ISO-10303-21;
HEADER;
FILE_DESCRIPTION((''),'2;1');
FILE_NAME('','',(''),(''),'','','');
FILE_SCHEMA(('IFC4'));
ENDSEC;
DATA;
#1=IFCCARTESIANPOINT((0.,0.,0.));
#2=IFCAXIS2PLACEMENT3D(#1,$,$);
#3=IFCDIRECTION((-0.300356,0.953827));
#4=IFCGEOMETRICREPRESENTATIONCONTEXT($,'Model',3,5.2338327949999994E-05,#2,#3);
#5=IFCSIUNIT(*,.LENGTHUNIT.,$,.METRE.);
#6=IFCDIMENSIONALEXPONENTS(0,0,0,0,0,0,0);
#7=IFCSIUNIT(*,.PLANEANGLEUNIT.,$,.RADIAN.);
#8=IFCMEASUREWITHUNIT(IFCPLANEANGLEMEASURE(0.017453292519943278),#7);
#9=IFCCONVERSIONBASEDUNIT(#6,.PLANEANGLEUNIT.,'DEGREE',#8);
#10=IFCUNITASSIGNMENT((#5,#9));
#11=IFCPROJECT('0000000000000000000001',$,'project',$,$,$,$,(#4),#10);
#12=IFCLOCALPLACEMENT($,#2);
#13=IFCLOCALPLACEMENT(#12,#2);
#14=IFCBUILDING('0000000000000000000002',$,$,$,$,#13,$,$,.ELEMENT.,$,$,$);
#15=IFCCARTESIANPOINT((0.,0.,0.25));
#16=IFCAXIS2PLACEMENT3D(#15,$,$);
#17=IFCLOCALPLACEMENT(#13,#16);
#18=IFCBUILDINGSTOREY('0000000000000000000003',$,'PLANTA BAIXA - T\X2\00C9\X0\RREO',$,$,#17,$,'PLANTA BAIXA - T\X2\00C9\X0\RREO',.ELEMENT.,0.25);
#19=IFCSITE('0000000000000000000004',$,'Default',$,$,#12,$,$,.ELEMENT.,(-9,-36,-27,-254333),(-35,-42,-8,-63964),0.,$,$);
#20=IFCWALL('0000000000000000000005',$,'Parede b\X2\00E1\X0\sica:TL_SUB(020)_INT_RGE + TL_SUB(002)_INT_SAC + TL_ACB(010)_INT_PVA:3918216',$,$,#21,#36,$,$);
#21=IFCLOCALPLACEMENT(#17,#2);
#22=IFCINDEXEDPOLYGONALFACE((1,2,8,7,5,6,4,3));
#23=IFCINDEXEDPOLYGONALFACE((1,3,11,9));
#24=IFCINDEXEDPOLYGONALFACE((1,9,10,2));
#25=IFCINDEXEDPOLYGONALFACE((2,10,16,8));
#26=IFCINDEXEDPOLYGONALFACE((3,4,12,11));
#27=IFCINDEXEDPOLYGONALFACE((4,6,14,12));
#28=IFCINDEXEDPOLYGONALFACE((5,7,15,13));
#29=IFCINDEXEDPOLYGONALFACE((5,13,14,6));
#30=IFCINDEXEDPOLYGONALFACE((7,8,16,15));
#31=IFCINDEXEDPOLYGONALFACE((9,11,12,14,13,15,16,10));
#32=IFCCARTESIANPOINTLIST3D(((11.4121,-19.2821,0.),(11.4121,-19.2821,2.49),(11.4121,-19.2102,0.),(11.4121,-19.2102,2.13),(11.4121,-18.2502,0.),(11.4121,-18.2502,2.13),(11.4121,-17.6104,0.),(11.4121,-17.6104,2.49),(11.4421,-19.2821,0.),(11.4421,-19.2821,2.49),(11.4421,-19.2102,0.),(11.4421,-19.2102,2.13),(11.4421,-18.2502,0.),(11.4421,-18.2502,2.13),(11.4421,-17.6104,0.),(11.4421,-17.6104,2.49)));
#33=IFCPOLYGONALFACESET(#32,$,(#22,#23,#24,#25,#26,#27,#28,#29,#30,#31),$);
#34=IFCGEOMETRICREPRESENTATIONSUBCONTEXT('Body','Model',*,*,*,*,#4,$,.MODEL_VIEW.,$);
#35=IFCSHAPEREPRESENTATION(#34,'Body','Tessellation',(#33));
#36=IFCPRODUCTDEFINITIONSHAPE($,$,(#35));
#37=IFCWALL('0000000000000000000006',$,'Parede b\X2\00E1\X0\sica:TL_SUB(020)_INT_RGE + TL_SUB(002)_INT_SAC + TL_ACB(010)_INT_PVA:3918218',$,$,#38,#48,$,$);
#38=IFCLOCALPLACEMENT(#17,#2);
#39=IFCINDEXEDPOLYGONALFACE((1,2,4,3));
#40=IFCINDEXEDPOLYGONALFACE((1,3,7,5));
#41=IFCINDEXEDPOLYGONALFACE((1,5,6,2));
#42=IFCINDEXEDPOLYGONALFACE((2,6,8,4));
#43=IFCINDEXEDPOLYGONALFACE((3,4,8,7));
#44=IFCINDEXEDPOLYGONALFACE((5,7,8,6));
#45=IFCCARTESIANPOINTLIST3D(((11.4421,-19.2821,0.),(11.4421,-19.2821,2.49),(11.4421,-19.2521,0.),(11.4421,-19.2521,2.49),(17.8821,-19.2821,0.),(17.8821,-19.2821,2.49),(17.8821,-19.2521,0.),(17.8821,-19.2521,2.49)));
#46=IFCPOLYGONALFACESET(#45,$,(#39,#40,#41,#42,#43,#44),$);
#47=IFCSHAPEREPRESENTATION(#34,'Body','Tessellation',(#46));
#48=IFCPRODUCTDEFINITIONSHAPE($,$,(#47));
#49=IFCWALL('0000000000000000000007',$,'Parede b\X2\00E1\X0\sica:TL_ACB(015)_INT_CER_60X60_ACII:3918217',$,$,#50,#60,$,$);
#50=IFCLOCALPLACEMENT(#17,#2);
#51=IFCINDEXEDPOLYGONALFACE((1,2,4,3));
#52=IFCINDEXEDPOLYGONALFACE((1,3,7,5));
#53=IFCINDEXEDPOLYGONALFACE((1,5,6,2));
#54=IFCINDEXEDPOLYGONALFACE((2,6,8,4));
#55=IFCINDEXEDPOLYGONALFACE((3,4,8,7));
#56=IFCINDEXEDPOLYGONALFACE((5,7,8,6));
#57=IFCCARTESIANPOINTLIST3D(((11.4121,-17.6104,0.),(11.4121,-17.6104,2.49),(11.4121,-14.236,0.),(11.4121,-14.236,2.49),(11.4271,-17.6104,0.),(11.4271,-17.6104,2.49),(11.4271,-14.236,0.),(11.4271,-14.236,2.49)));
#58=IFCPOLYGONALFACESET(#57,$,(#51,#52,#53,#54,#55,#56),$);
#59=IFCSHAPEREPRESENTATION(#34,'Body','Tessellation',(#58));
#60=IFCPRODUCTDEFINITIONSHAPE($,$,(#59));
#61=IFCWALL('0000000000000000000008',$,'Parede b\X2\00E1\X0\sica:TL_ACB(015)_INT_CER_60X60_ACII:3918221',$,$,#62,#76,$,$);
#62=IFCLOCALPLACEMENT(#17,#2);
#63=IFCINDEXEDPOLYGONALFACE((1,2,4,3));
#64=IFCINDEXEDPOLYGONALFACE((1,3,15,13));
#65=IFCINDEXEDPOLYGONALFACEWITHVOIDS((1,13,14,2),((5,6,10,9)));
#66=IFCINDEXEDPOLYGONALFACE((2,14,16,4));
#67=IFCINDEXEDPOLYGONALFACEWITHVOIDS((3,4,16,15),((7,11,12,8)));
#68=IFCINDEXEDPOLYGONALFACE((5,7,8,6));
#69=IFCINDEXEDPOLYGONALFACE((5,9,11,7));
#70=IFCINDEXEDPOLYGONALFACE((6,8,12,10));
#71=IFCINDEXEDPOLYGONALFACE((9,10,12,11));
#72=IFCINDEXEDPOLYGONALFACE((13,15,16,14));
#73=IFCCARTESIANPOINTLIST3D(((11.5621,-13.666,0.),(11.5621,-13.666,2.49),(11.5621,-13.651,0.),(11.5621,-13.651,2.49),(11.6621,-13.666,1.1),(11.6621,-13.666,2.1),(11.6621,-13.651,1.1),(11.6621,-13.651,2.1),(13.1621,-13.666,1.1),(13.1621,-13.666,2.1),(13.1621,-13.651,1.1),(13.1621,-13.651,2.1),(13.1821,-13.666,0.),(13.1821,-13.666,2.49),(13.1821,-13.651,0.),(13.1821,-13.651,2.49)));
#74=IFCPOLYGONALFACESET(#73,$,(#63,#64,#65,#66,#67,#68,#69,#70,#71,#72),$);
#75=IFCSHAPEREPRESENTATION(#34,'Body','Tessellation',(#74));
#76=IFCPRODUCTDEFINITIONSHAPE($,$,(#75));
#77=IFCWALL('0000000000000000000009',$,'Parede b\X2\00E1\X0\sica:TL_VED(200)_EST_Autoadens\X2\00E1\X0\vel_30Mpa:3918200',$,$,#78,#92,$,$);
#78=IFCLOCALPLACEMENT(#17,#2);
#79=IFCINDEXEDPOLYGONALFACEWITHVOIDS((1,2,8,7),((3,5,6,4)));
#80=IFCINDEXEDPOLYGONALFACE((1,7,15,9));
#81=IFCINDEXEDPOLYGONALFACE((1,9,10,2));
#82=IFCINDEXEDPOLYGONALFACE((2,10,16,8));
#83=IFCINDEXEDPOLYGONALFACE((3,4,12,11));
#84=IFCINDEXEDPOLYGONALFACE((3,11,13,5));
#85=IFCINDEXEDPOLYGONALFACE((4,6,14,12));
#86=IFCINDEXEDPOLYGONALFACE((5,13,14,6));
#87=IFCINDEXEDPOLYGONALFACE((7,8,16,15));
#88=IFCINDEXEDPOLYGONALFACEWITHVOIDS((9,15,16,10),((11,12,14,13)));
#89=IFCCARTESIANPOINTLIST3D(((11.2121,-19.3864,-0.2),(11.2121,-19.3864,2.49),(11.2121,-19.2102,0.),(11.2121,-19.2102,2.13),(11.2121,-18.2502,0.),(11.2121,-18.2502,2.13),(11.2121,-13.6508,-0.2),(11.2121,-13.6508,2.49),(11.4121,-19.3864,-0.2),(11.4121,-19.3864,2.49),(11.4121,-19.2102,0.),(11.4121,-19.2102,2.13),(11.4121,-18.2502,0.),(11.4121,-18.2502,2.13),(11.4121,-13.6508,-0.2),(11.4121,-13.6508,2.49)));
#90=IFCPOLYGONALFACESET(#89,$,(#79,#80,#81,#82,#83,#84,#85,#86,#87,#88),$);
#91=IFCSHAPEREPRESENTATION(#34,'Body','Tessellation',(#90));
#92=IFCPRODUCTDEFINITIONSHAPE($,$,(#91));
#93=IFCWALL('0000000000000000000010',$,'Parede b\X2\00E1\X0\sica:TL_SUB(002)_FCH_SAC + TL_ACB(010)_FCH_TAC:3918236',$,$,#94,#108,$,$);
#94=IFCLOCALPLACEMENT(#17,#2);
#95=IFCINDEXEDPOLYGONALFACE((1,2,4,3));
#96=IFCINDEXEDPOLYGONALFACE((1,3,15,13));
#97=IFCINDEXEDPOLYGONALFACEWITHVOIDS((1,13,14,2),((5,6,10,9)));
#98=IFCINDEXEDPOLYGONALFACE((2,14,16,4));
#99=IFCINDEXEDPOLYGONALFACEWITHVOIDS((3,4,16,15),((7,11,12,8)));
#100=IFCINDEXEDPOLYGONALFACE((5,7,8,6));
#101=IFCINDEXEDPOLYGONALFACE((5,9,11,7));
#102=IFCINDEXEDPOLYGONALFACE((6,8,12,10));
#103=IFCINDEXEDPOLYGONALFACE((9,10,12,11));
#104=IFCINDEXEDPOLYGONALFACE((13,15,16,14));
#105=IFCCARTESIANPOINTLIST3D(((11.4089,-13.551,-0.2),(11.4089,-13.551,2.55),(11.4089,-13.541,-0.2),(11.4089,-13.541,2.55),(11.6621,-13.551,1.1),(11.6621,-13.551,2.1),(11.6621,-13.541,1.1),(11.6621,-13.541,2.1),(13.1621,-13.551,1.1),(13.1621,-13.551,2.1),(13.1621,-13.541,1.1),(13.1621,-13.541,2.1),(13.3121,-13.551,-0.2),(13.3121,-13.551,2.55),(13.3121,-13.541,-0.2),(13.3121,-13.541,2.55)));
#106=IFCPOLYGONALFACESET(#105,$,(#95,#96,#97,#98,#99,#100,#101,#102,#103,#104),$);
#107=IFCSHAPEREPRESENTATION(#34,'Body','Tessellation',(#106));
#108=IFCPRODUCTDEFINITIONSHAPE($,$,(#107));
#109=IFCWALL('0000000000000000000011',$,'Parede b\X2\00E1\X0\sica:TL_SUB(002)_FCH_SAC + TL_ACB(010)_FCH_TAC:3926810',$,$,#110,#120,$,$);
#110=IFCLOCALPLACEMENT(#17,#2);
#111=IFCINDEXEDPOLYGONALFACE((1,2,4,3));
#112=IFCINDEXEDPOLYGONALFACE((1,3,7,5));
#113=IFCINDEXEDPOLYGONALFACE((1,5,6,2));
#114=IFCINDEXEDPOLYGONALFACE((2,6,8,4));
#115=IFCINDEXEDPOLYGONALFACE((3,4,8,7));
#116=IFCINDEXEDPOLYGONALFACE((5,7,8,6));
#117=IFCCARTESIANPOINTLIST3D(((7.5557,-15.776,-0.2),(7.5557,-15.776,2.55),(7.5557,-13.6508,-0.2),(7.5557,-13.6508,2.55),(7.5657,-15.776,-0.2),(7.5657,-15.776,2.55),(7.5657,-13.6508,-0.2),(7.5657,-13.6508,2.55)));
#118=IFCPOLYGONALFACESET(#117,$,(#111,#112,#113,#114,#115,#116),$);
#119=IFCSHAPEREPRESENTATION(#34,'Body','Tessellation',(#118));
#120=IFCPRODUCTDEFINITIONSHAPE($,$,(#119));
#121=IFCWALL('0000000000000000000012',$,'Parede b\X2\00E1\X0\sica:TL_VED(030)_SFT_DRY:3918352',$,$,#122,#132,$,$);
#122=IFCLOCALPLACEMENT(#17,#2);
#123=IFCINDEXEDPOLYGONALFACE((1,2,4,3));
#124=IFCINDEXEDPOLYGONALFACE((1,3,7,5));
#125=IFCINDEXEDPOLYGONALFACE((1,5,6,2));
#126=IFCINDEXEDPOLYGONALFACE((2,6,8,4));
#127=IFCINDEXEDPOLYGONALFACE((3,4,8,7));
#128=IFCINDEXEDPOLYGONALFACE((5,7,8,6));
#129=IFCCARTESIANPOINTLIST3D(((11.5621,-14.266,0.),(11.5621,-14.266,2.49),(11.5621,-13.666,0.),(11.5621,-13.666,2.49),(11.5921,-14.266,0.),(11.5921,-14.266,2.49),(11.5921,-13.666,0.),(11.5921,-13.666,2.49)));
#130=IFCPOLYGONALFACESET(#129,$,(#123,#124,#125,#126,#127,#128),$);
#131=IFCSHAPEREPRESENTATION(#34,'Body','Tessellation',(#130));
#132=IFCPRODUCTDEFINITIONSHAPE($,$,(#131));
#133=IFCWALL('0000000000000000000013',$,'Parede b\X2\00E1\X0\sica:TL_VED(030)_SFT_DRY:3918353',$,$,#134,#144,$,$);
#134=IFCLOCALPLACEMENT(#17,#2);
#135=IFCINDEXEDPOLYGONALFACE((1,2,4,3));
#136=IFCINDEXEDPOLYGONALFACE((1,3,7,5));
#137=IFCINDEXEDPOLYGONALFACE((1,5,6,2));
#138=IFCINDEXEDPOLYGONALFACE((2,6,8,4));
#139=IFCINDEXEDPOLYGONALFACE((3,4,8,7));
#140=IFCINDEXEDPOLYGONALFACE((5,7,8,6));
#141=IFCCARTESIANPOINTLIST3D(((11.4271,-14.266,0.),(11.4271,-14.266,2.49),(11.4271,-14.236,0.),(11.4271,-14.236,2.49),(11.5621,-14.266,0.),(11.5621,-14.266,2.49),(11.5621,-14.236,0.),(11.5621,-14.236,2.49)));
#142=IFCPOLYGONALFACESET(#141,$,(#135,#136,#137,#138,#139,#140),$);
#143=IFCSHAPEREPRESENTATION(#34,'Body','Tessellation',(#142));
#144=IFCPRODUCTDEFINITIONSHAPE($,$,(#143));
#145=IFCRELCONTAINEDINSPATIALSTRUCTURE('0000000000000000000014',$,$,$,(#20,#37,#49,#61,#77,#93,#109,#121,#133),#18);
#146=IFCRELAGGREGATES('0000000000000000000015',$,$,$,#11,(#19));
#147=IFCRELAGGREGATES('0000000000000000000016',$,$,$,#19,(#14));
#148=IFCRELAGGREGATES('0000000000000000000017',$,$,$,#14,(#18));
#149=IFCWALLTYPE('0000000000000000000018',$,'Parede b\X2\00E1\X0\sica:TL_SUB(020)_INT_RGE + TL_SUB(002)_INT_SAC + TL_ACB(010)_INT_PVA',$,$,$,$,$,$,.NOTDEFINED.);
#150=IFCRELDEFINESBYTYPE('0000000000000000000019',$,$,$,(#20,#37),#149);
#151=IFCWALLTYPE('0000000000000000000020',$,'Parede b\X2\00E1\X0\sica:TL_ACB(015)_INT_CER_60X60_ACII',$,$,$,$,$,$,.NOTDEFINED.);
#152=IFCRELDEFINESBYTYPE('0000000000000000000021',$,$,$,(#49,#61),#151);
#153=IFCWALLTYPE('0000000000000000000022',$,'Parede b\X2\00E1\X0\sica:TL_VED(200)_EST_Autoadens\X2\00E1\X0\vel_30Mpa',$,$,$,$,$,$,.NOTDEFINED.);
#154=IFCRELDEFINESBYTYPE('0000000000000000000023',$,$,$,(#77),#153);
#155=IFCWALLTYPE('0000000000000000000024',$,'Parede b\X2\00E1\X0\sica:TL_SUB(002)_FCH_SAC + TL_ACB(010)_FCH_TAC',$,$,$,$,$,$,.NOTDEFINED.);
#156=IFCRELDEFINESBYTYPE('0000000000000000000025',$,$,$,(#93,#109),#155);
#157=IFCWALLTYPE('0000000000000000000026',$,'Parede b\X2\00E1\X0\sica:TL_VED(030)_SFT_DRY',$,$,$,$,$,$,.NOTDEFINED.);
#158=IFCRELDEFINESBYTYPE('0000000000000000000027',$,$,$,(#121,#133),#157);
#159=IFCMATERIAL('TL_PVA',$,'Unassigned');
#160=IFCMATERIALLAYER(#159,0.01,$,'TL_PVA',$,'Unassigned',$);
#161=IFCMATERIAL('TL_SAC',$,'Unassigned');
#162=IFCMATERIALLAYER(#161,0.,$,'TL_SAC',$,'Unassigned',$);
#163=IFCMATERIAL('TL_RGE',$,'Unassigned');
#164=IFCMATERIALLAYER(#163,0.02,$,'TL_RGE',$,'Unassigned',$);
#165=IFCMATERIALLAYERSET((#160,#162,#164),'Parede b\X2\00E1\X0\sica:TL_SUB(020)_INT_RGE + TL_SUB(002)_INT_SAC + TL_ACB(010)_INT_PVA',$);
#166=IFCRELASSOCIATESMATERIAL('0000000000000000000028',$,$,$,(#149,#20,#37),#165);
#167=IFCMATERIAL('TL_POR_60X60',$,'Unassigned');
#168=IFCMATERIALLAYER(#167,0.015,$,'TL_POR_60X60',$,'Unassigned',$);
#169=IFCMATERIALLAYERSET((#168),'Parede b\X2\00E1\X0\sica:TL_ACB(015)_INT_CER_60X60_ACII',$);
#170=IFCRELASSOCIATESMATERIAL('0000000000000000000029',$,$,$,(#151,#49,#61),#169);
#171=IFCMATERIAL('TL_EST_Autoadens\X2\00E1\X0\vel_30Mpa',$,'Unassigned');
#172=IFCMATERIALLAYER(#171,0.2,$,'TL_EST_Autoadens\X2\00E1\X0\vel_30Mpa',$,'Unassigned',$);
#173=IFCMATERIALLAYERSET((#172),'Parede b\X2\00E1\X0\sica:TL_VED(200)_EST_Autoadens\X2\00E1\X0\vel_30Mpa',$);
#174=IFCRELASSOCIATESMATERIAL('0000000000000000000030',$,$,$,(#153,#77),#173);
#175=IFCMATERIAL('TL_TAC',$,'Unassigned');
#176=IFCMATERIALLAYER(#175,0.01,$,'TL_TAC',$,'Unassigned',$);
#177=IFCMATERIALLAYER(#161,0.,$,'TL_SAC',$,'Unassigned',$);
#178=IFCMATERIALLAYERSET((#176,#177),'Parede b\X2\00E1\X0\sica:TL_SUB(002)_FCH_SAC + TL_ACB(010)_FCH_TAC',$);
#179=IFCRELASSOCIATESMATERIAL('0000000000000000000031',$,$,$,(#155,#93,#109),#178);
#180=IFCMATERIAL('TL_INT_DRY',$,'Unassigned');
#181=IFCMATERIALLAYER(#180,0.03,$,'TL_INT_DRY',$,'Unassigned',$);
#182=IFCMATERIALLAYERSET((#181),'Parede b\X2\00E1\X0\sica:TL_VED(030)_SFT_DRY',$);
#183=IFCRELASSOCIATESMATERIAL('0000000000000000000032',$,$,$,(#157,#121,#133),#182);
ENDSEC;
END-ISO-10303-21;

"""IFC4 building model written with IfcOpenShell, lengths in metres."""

from ifc_helpers import new_model, entity, si_unit, converted_unit, direction, frame, frame_2d, origin, place, context, subcontext, project, spatial, rectangle, extrude, material, layer, layer_set, layer_usage, type_object, element, save


model = new_model("IFC4")

# Units and contexts
model_context = context("Model", 3, precision=5.2338327949999994e-05, world=origin(), true_north=direction((-0.300356, 0.953827)))
body_context = subcontext(model_context, "Body", "Model", "MODEL_VIEW")
ifc_project = project(units=[si_unit("LENGTHUNIT", "METRE"), converted_unit("PLANEANGLEUNIT", "DEGREE", entity("IfcPlaneAngleMeasure", 0.017453292519943278), si_unit("PLANEANGLEUNIT", "RADIAN"), dimensions=[0, 0, 0, 0, 0, 0, 0])], contexts=[model_context])

# Site, building, storey
site_placement = place(None, origin())
site = spatial("IfcSite", under=ifc_project, at=site_placement, Name="Default", CompositionType="ELEMENT", RefLatitude=(-9, -36, -27, -254333), RefLongitude=(-35, -42, -8, -63964), RefElevation=0.0)
building_placement = place(site_placement, origin())
building = spatial("IfcBuilding", under=site, at=building_placement, CompositionType="ELEMENT")
storey_placement = place(building_placement, frame((0.0, 0.0, 0.25)))
storey = spatial("IfcBuildingStorey", under=building, at=storey_placement, Name="PLANTA BAIXA - TÉRREO", LongName="PLANTA BAIXA - TÉRREO", CompositionType="ELEMENT", Elevation=0.25)

# Shared definitions
ifc_material_1 = material(Name="TL_POR_60X60", Category="Unassigned")

# Shared definitions
ifc_material_2 = material(Name="TL_EST_Autoadensável_30Mpa", Category="Unassigned")

# Wall, opening
ifc_material_3 = material(Name="TL_PVA", Category="Unassigned")
ifc_layer_1 = layer(ifc_material_3, 0.01, Name="TL_PVA", Category="Unassigned")
ifc_material_4 = material(Name="TL_SAC", Category="Unassigned")
ifc_layer_2 = layer(ifc_material_4, 0.0, Name="TL_SAC", Category="Unassigned")
ifc_material_5 = material(Name="TL_RGE", Category="Unassigned")
ifc_layer_3 = layer(ifc_material_5, 0.02, Name="TL_RGE", Category="Unassigned")
ifc_layer_set_1 = layer_set([ifc_layer_1, ifc_layer_2, ifc_layer_3], Name="Parede básica:TL_SUB(020)_INT_RGE + TL_SUB(002)_INT_SAC + TL_ACB(010)_INT_PVA")
ifc_layer_usage_1 = layer_usage(ifc_layer_set_1, "AXIS2", "POSITIVE", -0.015)
wall_type_1 = type_object("IfcWallType", Name="Parede básica:TL_SUB(020)_INT_RGE + TL_SUB(002)_INT_SAC + TL_ACB(010)_INT_PVA", PredefinedType="NOTDEFINED", material=ifc_layer_set_1)
wall_1_placement = place(storey_placement, frame((11.4271, -19.2821, 0.0), z_axis=(0.0, 0.0, 1.0), x_axis=(0.0, 1.0, 0.0)))
wall_1 = element("IfcWall", 1, at=wall_1_placement, inside=storey, type_object=wall_type_1, material=ifc_layer_usage_1, Name="Parede básica:TL_SUB(020)_INT_RGE + TL_SUB(002)_INT_SAC + TL_ACB(010)_INT_PVA:3918216", context=body_context, shape_type="SweptSolid", body=[
    extrude(rectangle(XDim=1.6717, YDim=0.03, at=frame_2d((0.8359, 0.0), x_axis=(-1.0, 0.0))), origin(), (0.0, 0.0, 1.0), 2.49),
])
opening_1_placement = place(wall_1_placement, frame((19.2821, 11.4271, 0.0)))
element("IfcOpeningElement", 2, at=opening_1_placement, cuts=wall_1, PredefinedType="OPENING", context=body_context, shape_type="SweptSolid", body=[
    extrude(rectangle(XDim=2.13, YDim=0.96, at=frame_2d((0.0, 0.0), x_axis=(0.0, 1.0))), frame((-18.7302, -12.9361, 1.065), z_axis=(0.0, 1.0, 0.0), x_axis=(-1.0, 0.0, 0.0)), (0.0, 0.0, 1.0), 3.048),
])

# Walls
ifc_layer_usage_2 = layer_usage(ifc_layer_set_1, "AXIS2", "NEGATIVE", 0.015)
wall_2_placement = place(storey_placement, frame((11.4421, -19.2671, 0.0)))
element("IfcWall", 3, at=wall_2_placement, inside=storey, type_object=wall_type_1, material=ifc_layer_usage_2, Name="Parede básica:TL_SUB(020)_INT_RGE + TL_SUB(002)_INT_SAC + TL_ACB(010)_INT_PVA:3918218", context=body_context, shape_type="SweptSolid", body=[
    extrude(rectangle(XDim=6.44, YDim=0.03, at=frame_2d((3.22, 0.0), x_axis=(-1.0, 0.0))), origin(), (0.0, 0.0, 1.0), 2.49),
])
ifc_layer_4 = layer(ifc_material_1, 0.015, Name="TL_POR_60X60", Category="Unassigned")
ifc_layer_set_2 = layer_set([ifc_layer_4], Name="Parede básica:TL_ACB(015)_INT_CER_60X60_ACII")
ifc_layer_usage_3 = layer_usage(ifc_layer_set_2, "AXIS2", "POSITIVE", -0.0075)
wall_type_2 = type_object("IfcWallType", Name="Parede básica:TL_ACB(015)_INT_CER_60X60_ACII", PredefinedType="NOTDEFINED", material=ifc_layer_set_2)
wall_3_placement = place(storey_placement, frame((11.4196, -17.6104, 0.0), z_axis=(0.0, 0.0, 1.0), x_axis=(0.0, 1.0, 0.0)))
element("IfcWall", 4, at=wall_3_placement, inside=storey, type_object=wall_type_2, material=ifc_layer_usage_3, Name="Parede básica:TL_ACB(015)_INT_CER_60X60_ACII:3918217", context=body_context, shape_type="SweptSolid", body=[
    extrude(rectangle(XDim=3.3744, YDim=0.015, at=frame_2d((1.6872, 0.0), x_axis=(-1.0, 0.0))), origin(), (0.0, 0.0, 1.0), 2.49),
])

# Walls, openings
ifc_layer_usage_4 = layer_usage(ifc_layer_set_2, "AXIS2", "POSITIVE", -0.0075)
wall_4_placement = place(storey_placement, frame((11.5621, -13.6585, 0.0)))
wall_4 = element("IfcWall", 5, at=wall_4_placement, inside=storey, type_object=wall_type_2, material=ifc_layer_usage_4, Name="Parede básica:TL_ACB(015)_INT_CER_60X60_ACII:3918221", context=body_context, shape_type="SweptSolid", body=[
    extrude(rectangle(XDim=1.62, YDim=0.015, at=frame_2d((0.81, 0.0), x_axis=(-1.0, 0.0))), origin(), (0.0, 0.0, 1.0), 2.49),
])
opening_2_placement = place(wall_4_placement, frame((-11.5621, 13.6585, 1.1)))
element("IfcOpeningElement", 6, at=opening_2_placement, cuts=wall_4, PredefinedType="OPENING", context=body_context, shape_type="SweptSolid", body=[
    extrude(rectangle(XDim=1.0, YDim=1.5, at=frame_2d((0.0, 0.0), x_axis=(0.0, 1.0))), frame((12.4121, -15.175, 0.5), z_axis=(0.0, 1.0, 0.0), x_axis=(1.0, 0.0, 0.0)), (0.0, 0.0, 1.0), 3.048),
])
ifc_layer_5 = layer(ifc_material_2, 0.2, Name="TL_EST_Autoadensável_30Mpa", Category="Unassigned")
ifc_layer_set_3 = layer_set([ifc_layer_5], Name="Parede básica:TL_VED(200)_EST_Autoadensável_30Mpa")
ifc_layer_usage_5 = layer_usage(ifc_layer_set_3, "AXIS2", "POSITIVE", -0.1)
wall_type_3 = type_object("IfcWallType", Name="Parede básica:TL_VED(200)_EST_Autoadensável_30Mpa", PredefinedType="NOTDEFINED", material=ifc_layer_set_3)
wall_5_placement = place(storey_placement, frame((11.3121, -13.6508, -0.2), z_axis=(0.0, 0.0, 1.0), x_axis=(0.0, -1.0, 0.0)))
wall_5 = element("IfcWall", 7, at=wall_5_placement, inside=storey, type_object=wall_type_3, material=ifc_layer_usage_5, Name="Parede básica:TL_VED(200)_EST_Autoadensável_30Mpa:3918200", context=body_context, shape_type="SweptSolid", body=[
    extrude(rectangle(XDim=5.7355, YDim=0.2, at=frame_2d((2.8678, 0.0), x_axis=(-1.0, 0.0))), origin(), (0.0, 0.0, 1.0), 2.69),
])
opening_3_placement = place(wall_5_placement, frame((4.5993, -0.1, 0.2)))
element("IfcOpeningElement", 8, at=opening_3_placement, cuts=wall_5, PredefinedType="OPENING", context=body_context, shape_type="SweptSolid", body=[
    extrude(rectangle(XDim=2.13, YDim=0.96, at=frame_2d((1.065, 0.48), x_axis=(1.0, 0.0))), frame((0.0, 0.0, 0.0), z_axis=(0.0, 1.0, 0.0), x_axis=(0.0, 0.0, 1.0)), (0.0, 0.0, 1.0), 0.2),
])
ifc_material_6 = material(Name="TL_TAC", Category="Unassigned")
ifc_layer_6 = layer(ifc_material_6, 0.01, Name="TL_TAC", Category="Unassigned")
ifc_layer_7 = layer(ifc_material_4, 0.0, Name="TL_SAC", Category="Unassigned")
ifc_layer_set_4 = layer_set([ifc_layer_6, ifc_layer_7], Name="Parede básica:TL_SUB(002)_FCH_SAC + TL_ACB(010)_FCH_TAC")
ifc_layer_usage_6 = layer_usage(ifc_layer_set_4, "AXIS2", "POSITIVE", -0.005)
wall_type_4 = type_object("IfcWallType", Name="Parede básica:TL_SUB(002)_FCH_SAC + TL_ACB(010)_FCH_TAC", PredefinedType="NOTDEFINED", material=ifc_layer_set_4)
wall_6_placement = place(storey_placement, frame((11.4089, -13.546, -0.2)))
wall_6 = element("IfcWall", 9, at=wall_6_placement, inside=storey, type_object=wall_type_4, material=ifc_layer_usage_6, Name="Parede básica:TL_SUB(002)_FCH_SAC + TL_ACB(010)_FCH_TAC:3918236", context=body_context, shape_type="SweptSolid", body=[
    extrude(rectangle(XDim=1.9032, YDim=0.01, at=frame_2d((0.9516, 0.0), x_axis=(-1.0, 0.0))), origin(), (0.0, 0.0, 1.0), 2.75),
])
opening_4_placement = place(wall_6_placement, frame((-11.4089, 13.546, 1.3)))
element("IfcOpeningElement", 10, at=opening_4_placement, cuts=wall_6, PredefinedType="OPENING", context=body_context, shape_type="SweptSolid", body=[
    extrude(rectangle(XDim=1.0, YDim=1.5, at=frame_2d((0.0, 0.0), x_axis=(0.0, 1.0))), frame((12.4121, -15.175, 0.5), z_axis=(0.0, 1.0, 0.0), x_axis=(1.0, 0.0, 0.0)), (0.0, 0.0, 1.0), 3.048),
])

# Walls
ifc_layer_usage_7 = layer_usage(ifc_layer_set_4, "AXIS2", "POSITIVE", -0.005)
wall_7_placement = place(storey_placement, frame((7.5607, -13.6508, -0.2), z_axis=(0.0, 0.0, 1.0), x_axis=(0.0, -1.0, 0.0)))
element("IfcWall", 11, at=wall_7_placement, inside=storey, type_object=wall_type_4, material=ifc_layer_usage_7, Name="Parede básica:TL_SUB(002)_FCH_SAC + TL_ACB(010)_FCH_TAC:3926810", context=body_context, shape_type="SweptSolid", body=[
    extrude(rectangle(XDim=2.1251, YDim=0.01, at=frame_2d((1.0626, 0.0), x_axis=(-1.0, 0.0))), origin(), (0.0, 0.0, 1.0), 2.75),
])
ifc_material_7 = material(Name="TL_INT_DRY", Category="Unassigned")
ifc_layer_8 = layer(ifc_material_7, 0.03, Name="TL_INT_DRY", Category="Unassigned")
ifc_layer_set_5 = layer_set([ifc_layer_8], Name="Parede básica:TL_VED(030)_SFT_DRY")
ifc_layer_usage_8 = layer_usage(ifc_layer_set_5, "AXIS2", "NEGATIVE", 0.015)
wall_type_5 = type_object("IfcWallType", Name="Parede básica:TL_VED(030)_SFT_DRY", PredefinedType="NOTDEFINED", material=ifc_layer_set_5)
wall_8_placement = place(storey_placement, frame((11.5771, -13.666, 0.0), z_axis=(0.0, 0.0, 1.0), x_axis=(0.0, -1.0, 0.0)))
element("IfcWall", 12, at=wall_8_placement, inside=storey, type_object=wall_type_5, material=ifc_layer_usage_8, Name="Parede básica:TL_VED(030)_SFT_DRY:3918352", context=body_context, shape_type="SweptSolid", body=[
    extrude(rectangle(XDim=0.6, YDim=0.03, at=frame_2d((0.3, 0.0), x_axis=(-1.0, 0.0))), origin(), (0.0, 0.0, 1.0), 2.49),
])
ifc_layer_usage_9 = layer_usage(ifc_layer_set_5, "AXIS2", "NEGATIVE", 0.015)
wall_9_placement = place(storey_placement, frame((11.5621, -14.251, 0.0), z_axis=(0.0, 0.0, 1.0), x_axis=(-1.0, 0.0, 0.0)))
element("IfcWall", 13, at=wall_9_placement, inside=storey, type_object=wall_type_5, material=ifc_layer_usage_9, Name="Parede básica:TL_VED(030)_SFT_DRY:3918353", context=body_context, shape_type="SweptSolid", body=[
    extrude(rectangle(XDim=0.135, YDim=0.03, at=frame_2d((0.0675, 0.0), x_axis=(-1.0, 0.0))), origin(), (0.0, 0.0, 1.0), 2.49),
])

save(model, "model.ifc")
